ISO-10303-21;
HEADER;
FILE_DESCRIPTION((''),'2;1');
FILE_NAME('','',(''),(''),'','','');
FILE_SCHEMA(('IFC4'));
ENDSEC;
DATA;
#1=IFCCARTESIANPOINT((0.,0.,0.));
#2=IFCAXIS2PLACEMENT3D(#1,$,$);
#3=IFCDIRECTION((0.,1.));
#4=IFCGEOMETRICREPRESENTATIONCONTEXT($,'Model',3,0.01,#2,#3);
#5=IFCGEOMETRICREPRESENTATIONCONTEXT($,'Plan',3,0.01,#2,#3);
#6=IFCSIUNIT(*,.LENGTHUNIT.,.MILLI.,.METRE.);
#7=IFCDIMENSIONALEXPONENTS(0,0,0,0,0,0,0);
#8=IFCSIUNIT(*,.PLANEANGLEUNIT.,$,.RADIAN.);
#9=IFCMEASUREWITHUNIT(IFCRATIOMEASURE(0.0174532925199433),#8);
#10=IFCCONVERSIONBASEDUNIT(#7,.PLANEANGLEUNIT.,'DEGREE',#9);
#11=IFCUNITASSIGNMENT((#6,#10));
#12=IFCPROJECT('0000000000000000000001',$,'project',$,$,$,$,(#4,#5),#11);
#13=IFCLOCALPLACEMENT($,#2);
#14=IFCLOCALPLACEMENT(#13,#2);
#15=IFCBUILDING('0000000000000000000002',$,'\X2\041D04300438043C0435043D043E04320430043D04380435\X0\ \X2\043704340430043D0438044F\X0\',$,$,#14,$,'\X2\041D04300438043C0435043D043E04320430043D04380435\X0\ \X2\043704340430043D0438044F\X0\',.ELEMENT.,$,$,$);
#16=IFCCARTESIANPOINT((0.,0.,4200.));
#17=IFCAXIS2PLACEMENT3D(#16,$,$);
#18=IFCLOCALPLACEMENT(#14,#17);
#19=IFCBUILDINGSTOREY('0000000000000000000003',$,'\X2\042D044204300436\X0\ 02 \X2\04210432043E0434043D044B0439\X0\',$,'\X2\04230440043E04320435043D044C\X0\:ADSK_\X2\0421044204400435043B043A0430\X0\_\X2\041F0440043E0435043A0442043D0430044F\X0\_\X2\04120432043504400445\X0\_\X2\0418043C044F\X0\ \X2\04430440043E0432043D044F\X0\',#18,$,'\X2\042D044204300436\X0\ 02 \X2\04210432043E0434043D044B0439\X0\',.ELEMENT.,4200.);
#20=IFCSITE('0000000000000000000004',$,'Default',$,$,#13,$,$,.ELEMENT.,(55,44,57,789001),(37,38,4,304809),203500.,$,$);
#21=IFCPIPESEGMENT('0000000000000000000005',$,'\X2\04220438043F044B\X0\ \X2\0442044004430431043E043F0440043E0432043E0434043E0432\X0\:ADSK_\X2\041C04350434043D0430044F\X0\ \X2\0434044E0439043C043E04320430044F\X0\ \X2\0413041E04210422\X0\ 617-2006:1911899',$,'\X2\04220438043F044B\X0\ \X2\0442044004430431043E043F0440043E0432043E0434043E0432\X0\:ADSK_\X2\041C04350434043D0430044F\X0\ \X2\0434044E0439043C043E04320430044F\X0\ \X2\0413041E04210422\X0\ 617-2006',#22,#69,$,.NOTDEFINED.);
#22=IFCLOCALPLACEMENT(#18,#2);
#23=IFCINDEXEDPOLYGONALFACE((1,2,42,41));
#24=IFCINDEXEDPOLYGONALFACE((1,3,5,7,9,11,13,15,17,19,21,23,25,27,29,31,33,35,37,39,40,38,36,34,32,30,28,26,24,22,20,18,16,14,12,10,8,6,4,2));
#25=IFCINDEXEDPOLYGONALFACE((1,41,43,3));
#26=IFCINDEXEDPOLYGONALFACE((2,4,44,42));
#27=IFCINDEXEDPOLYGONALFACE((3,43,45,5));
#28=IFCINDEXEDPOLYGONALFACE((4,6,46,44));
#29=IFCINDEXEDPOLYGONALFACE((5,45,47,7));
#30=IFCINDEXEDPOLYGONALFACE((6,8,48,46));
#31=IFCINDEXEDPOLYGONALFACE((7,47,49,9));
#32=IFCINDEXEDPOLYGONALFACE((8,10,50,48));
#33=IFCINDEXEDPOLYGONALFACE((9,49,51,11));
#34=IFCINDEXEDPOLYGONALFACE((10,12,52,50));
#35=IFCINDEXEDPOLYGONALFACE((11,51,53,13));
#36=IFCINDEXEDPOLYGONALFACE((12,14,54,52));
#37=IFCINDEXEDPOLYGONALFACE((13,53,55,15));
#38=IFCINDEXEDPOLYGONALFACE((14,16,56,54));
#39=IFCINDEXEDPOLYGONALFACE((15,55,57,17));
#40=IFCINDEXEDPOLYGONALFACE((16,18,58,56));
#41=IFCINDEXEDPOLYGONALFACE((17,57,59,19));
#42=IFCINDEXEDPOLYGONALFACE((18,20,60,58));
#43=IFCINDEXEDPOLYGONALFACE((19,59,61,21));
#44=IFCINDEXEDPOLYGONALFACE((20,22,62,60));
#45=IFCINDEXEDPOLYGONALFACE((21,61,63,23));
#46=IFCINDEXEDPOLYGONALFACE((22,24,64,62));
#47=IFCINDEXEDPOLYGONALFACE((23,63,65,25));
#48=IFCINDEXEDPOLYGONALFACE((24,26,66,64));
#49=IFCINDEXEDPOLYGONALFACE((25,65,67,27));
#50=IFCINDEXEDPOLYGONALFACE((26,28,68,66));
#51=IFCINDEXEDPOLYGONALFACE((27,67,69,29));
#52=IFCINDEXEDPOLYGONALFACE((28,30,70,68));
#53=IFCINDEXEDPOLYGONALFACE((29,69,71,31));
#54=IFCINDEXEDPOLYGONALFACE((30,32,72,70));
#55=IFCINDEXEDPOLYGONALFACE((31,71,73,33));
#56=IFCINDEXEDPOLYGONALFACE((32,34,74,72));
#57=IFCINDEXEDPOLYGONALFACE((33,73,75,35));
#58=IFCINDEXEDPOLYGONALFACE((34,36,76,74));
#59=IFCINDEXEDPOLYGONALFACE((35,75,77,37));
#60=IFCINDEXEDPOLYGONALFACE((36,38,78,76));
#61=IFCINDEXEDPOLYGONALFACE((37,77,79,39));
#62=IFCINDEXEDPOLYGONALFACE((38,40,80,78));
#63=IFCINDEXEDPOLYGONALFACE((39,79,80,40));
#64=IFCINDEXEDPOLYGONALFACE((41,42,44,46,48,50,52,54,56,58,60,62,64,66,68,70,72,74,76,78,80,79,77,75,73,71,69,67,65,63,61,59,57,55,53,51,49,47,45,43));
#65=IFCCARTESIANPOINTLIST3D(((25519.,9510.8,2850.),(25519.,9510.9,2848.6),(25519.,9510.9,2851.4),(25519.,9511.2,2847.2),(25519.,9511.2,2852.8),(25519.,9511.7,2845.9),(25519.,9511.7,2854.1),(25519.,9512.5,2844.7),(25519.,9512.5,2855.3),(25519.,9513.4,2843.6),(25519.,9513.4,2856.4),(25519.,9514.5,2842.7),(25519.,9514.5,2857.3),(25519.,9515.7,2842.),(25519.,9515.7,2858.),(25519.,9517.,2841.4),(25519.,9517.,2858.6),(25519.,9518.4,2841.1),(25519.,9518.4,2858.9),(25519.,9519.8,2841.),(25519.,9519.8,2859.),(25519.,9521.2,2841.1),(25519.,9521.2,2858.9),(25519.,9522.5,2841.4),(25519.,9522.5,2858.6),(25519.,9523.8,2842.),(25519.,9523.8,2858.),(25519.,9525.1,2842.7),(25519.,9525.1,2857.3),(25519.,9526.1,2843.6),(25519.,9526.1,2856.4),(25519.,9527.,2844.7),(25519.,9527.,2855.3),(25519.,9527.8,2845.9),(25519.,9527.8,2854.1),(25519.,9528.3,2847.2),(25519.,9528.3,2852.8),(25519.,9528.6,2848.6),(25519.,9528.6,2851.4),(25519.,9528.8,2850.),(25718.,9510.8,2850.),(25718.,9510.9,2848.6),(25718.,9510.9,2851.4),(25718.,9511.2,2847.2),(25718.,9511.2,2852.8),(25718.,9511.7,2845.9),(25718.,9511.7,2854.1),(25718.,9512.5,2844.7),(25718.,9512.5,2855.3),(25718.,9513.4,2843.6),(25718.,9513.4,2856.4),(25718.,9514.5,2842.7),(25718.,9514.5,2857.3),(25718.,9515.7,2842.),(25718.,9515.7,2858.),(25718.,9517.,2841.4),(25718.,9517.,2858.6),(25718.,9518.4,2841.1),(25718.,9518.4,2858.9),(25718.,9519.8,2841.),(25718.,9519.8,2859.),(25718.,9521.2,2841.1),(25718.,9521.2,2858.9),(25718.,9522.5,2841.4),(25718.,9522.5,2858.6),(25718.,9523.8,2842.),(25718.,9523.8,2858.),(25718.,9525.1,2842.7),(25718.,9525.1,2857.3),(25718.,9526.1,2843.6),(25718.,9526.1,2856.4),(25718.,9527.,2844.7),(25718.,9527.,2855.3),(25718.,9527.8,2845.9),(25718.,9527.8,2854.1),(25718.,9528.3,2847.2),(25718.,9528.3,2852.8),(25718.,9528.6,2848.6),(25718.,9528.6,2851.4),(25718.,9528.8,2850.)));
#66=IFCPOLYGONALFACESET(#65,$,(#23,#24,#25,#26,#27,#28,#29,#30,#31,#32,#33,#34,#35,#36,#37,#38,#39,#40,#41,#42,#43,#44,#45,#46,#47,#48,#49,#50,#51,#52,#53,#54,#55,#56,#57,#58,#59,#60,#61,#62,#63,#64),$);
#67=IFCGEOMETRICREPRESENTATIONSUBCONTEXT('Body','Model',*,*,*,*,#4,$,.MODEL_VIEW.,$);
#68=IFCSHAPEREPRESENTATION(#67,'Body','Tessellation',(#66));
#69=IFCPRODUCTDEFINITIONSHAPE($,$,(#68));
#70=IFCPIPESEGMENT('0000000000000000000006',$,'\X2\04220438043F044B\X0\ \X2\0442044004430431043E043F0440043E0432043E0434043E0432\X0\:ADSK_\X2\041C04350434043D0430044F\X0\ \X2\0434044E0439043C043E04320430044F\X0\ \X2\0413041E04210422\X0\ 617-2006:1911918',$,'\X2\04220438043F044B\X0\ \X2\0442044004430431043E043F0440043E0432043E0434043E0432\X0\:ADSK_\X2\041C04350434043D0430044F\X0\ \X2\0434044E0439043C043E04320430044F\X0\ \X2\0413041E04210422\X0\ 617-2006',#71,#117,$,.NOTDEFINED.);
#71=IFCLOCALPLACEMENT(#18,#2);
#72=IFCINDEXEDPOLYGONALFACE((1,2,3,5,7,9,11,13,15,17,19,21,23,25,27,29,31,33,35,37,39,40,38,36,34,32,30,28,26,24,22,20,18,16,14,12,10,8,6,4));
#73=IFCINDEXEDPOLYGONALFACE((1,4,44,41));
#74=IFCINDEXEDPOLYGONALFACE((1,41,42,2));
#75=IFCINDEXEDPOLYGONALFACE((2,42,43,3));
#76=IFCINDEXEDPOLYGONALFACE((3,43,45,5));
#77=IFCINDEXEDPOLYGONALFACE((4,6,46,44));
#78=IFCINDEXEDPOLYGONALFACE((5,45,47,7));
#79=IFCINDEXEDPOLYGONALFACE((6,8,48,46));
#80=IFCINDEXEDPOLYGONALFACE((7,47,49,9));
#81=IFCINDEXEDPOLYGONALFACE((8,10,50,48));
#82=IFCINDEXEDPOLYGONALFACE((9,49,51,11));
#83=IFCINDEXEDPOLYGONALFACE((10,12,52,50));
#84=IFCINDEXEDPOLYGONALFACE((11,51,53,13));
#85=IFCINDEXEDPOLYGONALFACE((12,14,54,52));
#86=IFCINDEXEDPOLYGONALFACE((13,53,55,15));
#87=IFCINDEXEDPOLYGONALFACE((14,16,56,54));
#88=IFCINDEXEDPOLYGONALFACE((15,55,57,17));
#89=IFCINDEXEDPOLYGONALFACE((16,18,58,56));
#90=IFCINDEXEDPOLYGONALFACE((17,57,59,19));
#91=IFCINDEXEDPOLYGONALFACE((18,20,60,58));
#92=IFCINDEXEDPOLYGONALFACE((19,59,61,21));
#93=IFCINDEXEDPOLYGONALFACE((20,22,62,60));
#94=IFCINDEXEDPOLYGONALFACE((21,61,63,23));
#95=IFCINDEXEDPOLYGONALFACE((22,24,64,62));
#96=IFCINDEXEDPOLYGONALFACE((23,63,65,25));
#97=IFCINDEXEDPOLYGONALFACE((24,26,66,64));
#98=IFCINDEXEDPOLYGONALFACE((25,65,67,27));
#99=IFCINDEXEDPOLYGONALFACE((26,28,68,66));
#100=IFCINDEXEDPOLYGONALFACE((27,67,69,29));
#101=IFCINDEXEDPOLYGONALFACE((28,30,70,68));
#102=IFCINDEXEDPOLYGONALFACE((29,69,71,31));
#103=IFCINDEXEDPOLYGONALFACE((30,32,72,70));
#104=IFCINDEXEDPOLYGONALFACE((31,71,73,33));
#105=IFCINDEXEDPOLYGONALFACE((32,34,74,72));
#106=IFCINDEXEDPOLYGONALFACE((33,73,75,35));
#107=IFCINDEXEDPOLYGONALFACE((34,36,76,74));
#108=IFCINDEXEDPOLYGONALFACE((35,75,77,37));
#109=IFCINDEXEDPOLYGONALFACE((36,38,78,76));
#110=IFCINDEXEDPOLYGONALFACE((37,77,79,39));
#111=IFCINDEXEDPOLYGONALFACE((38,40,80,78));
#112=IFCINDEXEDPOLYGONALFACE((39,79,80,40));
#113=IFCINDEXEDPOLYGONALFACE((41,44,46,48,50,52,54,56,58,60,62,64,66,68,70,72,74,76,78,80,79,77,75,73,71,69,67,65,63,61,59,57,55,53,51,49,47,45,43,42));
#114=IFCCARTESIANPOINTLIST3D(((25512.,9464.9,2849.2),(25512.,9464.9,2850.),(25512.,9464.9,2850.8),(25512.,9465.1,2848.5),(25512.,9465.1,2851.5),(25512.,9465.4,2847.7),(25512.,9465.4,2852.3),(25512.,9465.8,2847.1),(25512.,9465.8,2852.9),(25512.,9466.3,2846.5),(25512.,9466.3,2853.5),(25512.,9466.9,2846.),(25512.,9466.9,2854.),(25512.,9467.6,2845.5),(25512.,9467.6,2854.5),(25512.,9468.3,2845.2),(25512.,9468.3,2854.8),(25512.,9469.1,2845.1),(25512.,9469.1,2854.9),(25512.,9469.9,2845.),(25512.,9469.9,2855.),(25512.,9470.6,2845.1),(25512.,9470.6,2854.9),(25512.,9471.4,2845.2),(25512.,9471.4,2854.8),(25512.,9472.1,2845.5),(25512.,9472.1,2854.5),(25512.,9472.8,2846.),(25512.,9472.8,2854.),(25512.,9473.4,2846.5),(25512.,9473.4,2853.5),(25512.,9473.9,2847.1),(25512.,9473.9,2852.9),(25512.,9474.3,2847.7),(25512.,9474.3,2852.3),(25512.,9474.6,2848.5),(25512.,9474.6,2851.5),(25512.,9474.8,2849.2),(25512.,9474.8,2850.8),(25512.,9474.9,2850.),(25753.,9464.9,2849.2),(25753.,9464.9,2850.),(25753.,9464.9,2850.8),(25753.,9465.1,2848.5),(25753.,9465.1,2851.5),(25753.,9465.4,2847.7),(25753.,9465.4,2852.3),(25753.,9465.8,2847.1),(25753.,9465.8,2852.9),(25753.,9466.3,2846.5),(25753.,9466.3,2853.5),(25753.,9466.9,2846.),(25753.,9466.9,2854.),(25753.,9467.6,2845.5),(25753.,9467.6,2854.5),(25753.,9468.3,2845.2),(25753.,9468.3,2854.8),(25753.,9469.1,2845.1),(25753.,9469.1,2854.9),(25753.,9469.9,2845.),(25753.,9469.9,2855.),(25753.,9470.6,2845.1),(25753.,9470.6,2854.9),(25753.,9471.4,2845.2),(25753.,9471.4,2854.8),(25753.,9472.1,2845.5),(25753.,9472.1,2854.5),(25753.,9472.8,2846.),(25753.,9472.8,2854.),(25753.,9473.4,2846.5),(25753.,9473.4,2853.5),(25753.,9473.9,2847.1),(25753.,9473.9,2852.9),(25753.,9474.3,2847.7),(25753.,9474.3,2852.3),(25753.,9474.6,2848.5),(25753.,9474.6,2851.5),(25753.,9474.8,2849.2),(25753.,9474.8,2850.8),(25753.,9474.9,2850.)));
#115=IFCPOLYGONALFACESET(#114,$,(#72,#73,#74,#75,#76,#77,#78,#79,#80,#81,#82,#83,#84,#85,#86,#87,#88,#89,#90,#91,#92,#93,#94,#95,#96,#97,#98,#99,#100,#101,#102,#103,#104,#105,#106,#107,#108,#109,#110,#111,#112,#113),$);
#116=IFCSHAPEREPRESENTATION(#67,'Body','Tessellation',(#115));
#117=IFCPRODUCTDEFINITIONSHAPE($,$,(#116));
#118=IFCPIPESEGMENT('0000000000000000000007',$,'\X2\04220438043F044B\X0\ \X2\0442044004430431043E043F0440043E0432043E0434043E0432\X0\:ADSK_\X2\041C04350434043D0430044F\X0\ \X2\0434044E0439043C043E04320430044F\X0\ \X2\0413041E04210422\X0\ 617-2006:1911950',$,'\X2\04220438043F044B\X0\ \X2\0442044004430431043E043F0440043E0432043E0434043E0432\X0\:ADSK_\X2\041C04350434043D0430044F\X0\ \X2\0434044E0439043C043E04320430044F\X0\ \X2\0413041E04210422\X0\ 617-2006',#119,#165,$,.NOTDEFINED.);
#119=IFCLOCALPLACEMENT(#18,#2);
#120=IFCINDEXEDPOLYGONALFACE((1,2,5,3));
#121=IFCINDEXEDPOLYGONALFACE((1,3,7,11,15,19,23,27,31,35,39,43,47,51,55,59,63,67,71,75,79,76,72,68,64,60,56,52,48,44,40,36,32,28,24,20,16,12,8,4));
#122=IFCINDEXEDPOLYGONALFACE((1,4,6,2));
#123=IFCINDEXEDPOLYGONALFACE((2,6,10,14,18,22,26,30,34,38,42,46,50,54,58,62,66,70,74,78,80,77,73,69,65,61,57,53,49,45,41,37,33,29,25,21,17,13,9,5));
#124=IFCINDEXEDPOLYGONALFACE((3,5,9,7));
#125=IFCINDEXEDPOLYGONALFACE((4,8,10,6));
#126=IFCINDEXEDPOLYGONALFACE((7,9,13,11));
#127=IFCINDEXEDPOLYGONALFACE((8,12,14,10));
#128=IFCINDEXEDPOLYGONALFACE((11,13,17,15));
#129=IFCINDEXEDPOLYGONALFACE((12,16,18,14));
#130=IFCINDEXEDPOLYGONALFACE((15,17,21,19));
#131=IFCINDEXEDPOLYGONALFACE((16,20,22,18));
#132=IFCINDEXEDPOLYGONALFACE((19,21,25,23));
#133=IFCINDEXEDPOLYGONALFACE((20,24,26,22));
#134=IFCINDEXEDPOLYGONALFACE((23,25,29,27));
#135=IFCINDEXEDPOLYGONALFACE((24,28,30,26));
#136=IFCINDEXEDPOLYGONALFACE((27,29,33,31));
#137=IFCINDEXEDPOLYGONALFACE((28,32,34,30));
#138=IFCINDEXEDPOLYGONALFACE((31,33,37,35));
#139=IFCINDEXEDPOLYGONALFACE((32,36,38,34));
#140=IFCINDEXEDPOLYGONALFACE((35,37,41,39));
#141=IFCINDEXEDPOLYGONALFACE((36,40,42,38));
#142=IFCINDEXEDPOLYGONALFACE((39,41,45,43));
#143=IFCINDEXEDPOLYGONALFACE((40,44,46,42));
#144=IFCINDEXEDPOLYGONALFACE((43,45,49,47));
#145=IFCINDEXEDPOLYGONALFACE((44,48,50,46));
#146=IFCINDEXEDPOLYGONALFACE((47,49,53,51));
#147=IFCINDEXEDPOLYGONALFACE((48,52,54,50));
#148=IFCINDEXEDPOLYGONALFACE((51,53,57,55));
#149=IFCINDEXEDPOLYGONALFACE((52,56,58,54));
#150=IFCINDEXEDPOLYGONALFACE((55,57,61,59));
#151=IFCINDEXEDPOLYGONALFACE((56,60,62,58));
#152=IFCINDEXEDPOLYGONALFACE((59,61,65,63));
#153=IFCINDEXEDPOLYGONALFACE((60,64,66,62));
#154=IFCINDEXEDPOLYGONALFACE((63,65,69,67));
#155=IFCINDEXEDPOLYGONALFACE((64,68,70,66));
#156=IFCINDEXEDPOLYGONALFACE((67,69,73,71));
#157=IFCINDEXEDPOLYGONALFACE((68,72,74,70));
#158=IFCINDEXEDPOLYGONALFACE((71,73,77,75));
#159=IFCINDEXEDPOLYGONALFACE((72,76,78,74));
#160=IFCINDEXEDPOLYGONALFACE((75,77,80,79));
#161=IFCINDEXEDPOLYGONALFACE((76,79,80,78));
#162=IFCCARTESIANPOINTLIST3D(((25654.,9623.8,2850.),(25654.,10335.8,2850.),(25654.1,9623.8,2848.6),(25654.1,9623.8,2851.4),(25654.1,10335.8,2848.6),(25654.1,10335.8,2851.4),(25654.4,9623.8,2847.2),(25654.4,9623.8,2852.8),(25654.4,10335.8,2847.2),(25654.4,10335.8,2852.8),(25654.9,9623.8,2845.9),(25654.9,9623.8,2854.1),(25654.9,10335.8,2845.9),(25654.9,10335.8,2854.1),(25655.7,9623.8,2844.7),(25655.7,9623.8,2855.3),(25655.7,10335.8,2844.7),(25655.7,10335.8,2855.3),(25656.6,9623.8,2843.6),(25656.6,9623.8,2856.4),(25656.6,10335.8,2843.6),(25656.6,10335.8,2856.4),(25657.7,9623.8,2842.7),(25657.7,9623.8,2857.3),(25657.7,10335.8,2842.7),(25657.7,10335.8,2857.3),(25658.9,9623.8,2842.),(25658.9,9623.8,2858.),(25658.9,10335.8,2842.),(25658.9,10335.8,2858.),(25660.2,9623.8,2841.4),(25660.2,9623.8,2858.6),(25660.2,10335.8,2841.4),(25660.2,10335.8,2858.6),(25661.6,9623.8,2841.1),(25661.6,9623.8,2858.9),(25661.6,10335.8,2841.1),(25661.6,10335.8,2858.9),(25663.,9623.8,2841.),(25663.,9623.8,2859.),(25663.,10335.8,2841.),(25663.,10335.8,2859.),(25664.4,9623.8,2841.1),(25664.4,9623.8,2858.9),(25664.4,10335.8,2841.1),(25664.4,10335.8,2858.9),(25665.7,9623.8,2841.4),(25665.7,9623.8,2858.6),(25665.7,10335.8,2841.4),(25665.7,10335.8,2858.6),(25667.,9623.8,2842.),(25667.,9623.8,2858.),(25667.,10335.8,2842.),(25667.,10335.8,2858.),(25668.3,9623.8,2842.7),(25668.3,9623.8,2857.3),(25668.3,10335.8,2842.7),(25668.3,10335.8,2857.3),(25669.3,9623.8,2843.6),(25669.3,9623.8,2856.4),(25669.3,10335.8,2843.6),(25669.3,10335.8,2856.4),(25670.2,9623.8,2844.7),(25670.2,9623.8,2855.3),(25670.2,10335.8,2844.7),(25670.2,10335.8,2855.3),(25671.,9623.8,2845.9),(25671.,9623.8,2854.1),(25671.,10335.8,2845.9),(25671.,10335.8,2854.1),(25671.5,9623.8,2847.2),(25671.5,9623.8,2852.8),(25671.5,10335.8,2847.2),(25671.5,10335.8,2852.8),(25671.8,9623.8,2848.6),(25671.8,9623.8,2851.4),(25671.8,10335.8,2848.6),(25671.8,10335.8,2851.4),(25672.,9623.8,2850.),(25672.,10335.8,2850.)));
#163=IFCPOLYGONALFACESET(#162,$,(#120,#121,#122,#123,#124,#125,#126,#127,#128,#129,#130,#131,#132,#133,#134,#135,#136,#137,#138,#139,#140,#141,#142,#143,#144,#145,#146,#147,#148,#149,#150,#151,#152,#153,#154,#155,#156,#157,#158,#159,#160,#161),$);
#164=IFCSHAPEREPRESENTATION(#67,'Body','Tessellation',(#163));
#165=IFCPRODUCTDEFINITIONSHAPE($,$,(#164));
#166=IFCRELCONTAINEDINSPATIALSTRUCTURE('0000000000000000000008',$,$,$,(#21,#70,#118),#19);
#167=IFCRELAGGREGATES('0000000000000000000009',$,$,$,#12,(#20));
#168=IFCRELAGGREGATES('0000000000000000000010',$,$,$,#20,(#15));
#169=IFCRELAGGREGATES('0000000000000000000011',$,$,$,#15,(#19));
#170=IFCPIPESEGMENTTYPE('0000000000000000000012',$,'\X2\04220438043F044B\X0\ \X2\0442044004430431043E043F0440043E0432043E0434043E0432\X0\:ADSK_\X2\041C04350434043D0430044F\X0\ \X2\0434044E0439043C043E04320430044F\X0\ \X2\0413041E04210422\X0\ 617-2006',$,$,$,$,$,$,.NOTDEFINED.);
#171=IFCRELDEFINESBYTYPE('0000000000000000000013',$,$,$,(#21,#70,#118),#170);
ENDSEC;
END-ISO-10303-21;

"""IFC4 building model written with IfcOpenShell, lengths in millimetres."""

from ifc_helpers import new_model, entity, si_unit, converted_unit, direction, frame, origin, place, context, subcontext, project, spatial, indexed_curve, outline, extrude, type_object, element, save


model = new_model("IFC4")

# Units and contexts
model_context = context("Model", 3, precision=0.01, world=origin(), true_north=direction((0.0, 1.0)))
plan_context = context("Plan", 3, precision=0.01, world=origin(), true_north=direction((0.0, 1.0)))
body_context = subcontext(model_context, "Body", "Model", "MODEL_VIEW")
ifc_project = project(units=[si_unit("LENGTHUNIT", "METRE", prefix="MILLI"), converted_unit("PLANEANGLEUNIT", "DEGREE", entity("IfcRatioMeasure", 0.0174532925199433), si_unit("PLANEANGLEUNIT", "RADIAN"), dimensions=[0, 0, 0, 0, 0, 0, 0])], contexts=[model_context, plan_context])

# Site, building, storey
site_placement = place(None, origin())
site = spatial("IfcSite", under=ifc_project, at=site_placement, Name="Default", CompositionType="ELEMENT", RefLatitude=(55, 44, 57, 789001), RefLongitude=(37, 38, 4, 304809), RefElevation=203500.0)
building_placement = place(site_placement, origin())
building = spatial("IfcBuilding", under=site, at=building_placement, Name="Наименование здания", LongName="Наименование здания", CompositionType="ELEMENT")
storey_placement = place(building_placement, frame((0.0, 0.0, 4200.0)))
storey = spatial("IfcBuildingStorey", under=building, at=storey_placement, Name="Этаж 02 Сводный", ObjectType="Уровень:ADSK_Стрелка_Проектная_Вверх_Имя уровня", LongName="Этаж 02 Сводный", CompositionType="ELEMENT", Elevation=4200.0)

# Pipe segments
pipe_segment_type_1 = type_object("IfcPipeSegmentType", Name="Типы трубопроводов:ADSK_Медная дюймовая ГОСТ 617-2006", PredefinedType="NOTDEFINED")
placement = place(storey_placement, origin())
element("IfcPipeSegment", 1, at=placement, inside=storey, type_object=pipe_segment_type_1, Name="Типы трубопроводов:ADSK_Медная дюймовая ГОСТ 617-2006:1911899", ObjectType="Типы трубопроводов:ADSK_Медная дюймовая ГОСТ 617-2006", PredefinedType="NOTDEFINED", context=body_context, shape_type="SweptSolid", body=[
    extrude(outline(indexed_curve([(9.0, 0.0), (8.9, 1.4), (8.6, 2.8), (8.0, 4.1), (7.3, 5.3), (6.4, 6.4), (5.3, 7.3), (4.1, 8.0), (2.8, 8.6), (1.4, 8.9), (0.0, 9.0), (-1.4, 8.9), (-2.8, 8.6), (-4.1, 8.0), (-5.3, 7.3), (-6.4, 6.4), (-7.3, 5.3), (-8.0, 4.1), (-8.6, 2.8), (-8.9, 1.4), (-9.0, 0.0), (-8.9, -1.4), (-8.6, -2.8), (-8.0, -4.1), (-7.3, -5.3), (-6.4, -6.4), (-5.3, -7.3), (-4.1, -8.0), (-2.8, -8.6), (-1.4, -8.9), (0.0, -9.0), (1.4, -8.9), (2.8, -8.6), (4.1, -8.0), (5.3, -7.3), (6.4, -6.4), (7.3, -5.3), (8.0, -4.1), (8.6, -2.8), (8.9, -1.4), (9.0, 0.0)], self_intersect=False)), frame((25519.0, 9519.8, 2850.0), z_axis=(1.0, 0.0, 0.0), x_axis=(0.0, -1.0, 0.0)), (0.0, 0.0, 1.0), 199.0),
])
element("IfcPipeSegment", 2, at=placement, inside=storey, type_object=pipe_segment_type_1, Name="Типы трубопроводов:ADSK_Медная дюймовая ГОСТ 617-2006:1911918", ObjectType="Типы трубопроводов:ADSK_Медная дюймовая ГОСТ 617-2006", PredefinedType="NOTDEFINED", context=body_context, shape_type="SweptSolid", body=[
    extrude(outline(indexed_curve([(5.0, 0.0), (4.9, 0.8), (4.8, 1.5), (4.5, 2.3), (4.0, 2.9), (3.5, 3.5), (2.9, 4.0), (2.3, 4.5), (1.5, 4.8), (0.8, 4.9), (0.0, 5.0), (-0.8, 4.9), (-1.5, 4.8), (-2.3, 4.5), (-2.9, 4.0), (-3.5, 3.5), (-4.0, 2.9), (-4.5, 2.3), (-4.8, 1.5), (-4.9, 0.8), (-5.0, 0.0), (-4.9, -0.8), (-4.8, -1.5), (-4.5, -2.3), (-4.0, -2.9), (-3.5, -3.5), (-2.9, -4.0), (-2.3, -4.5), (-1.5, -4.8), (-0.8, -4.9), (0.0, -5.0), (0.8, -4.9), (1.5, -4.8), (2.3, -4.5), (2.9, -4.0), (3.5, -3.5), (4.0, -2.9), (4.5, -2.3), (4.8, -1.5), (4.9, -0.8), (5.0, 0.0)], self_intersect=False)), frame((25512.0, 9469.9, 2850.0), z_axis=(1.0, 0.0, 0.0), x_axis=(0.0, -1.0, 0.0)), (0.0, 0.0, 1.0), 241.0),
])
element("IfcPipeSegment", 3, at=placement, inside=storey, type_object=pipe_segment_type_1, Name="Типы трубопроводов:ADSK_Медная дюймовая ГОСТ 617-2006:1911950", ObjectType="Типы трубопроводов:ADSK_Медная дюймовая ГОСТ 617-2006", PredefinedType="NOTDEFINED", context=body_context, shape_type="SweptSolid", body=[
    extrude(outline(indexed_curve([(9.0, 0.0), (8.9, 1.4), (8.6, 2.8), (8.0, 4.1), (7.3, 5.3), (6.4, 6.4), (5.3, 7.3), (4.1, 8.0), (2.8, 8.6), (1.4, 8.9), (0.0, 9.0), (-1.4, 8.9), (-2.8, 8.6), (-4.1, 8.0), (-5.3, 7.3), (-6.4, 6.4), (-7.3, 5.3), (-8.0, 4.1), (-8.6, 2.8), (-8.9, 1.4), (-9.0, 0.0), (-8.9, -1.4), (-8.6, -2.8), (-8.0, -4.1), (-7.3, -5.3), (-6.4, -6.4), (-5.3, -7.3), (-4.1, -8.0), (-2.8, -8.6), (-1.4, -8.9), (0.0, -9.0), (1.4, -8.9), (2.8, -8.6), (4.1, -8.0), (5.3, -7.3), (6.4, -6.4), (7.3, -5.3), (8.0, -4.1), (8.6, -2.8), (8.9, -1.4), (9.0, 0.0)], self_intersect=False)), frame((25663.0, 9623.8, 2850.0), z_axis=(0.0, 1.0, 0.0), x_axis=(1.0, 0.0, 0.0)), (0.0, 0.0, 1.0), 712.0),
])

save(model, "model.ifc")
